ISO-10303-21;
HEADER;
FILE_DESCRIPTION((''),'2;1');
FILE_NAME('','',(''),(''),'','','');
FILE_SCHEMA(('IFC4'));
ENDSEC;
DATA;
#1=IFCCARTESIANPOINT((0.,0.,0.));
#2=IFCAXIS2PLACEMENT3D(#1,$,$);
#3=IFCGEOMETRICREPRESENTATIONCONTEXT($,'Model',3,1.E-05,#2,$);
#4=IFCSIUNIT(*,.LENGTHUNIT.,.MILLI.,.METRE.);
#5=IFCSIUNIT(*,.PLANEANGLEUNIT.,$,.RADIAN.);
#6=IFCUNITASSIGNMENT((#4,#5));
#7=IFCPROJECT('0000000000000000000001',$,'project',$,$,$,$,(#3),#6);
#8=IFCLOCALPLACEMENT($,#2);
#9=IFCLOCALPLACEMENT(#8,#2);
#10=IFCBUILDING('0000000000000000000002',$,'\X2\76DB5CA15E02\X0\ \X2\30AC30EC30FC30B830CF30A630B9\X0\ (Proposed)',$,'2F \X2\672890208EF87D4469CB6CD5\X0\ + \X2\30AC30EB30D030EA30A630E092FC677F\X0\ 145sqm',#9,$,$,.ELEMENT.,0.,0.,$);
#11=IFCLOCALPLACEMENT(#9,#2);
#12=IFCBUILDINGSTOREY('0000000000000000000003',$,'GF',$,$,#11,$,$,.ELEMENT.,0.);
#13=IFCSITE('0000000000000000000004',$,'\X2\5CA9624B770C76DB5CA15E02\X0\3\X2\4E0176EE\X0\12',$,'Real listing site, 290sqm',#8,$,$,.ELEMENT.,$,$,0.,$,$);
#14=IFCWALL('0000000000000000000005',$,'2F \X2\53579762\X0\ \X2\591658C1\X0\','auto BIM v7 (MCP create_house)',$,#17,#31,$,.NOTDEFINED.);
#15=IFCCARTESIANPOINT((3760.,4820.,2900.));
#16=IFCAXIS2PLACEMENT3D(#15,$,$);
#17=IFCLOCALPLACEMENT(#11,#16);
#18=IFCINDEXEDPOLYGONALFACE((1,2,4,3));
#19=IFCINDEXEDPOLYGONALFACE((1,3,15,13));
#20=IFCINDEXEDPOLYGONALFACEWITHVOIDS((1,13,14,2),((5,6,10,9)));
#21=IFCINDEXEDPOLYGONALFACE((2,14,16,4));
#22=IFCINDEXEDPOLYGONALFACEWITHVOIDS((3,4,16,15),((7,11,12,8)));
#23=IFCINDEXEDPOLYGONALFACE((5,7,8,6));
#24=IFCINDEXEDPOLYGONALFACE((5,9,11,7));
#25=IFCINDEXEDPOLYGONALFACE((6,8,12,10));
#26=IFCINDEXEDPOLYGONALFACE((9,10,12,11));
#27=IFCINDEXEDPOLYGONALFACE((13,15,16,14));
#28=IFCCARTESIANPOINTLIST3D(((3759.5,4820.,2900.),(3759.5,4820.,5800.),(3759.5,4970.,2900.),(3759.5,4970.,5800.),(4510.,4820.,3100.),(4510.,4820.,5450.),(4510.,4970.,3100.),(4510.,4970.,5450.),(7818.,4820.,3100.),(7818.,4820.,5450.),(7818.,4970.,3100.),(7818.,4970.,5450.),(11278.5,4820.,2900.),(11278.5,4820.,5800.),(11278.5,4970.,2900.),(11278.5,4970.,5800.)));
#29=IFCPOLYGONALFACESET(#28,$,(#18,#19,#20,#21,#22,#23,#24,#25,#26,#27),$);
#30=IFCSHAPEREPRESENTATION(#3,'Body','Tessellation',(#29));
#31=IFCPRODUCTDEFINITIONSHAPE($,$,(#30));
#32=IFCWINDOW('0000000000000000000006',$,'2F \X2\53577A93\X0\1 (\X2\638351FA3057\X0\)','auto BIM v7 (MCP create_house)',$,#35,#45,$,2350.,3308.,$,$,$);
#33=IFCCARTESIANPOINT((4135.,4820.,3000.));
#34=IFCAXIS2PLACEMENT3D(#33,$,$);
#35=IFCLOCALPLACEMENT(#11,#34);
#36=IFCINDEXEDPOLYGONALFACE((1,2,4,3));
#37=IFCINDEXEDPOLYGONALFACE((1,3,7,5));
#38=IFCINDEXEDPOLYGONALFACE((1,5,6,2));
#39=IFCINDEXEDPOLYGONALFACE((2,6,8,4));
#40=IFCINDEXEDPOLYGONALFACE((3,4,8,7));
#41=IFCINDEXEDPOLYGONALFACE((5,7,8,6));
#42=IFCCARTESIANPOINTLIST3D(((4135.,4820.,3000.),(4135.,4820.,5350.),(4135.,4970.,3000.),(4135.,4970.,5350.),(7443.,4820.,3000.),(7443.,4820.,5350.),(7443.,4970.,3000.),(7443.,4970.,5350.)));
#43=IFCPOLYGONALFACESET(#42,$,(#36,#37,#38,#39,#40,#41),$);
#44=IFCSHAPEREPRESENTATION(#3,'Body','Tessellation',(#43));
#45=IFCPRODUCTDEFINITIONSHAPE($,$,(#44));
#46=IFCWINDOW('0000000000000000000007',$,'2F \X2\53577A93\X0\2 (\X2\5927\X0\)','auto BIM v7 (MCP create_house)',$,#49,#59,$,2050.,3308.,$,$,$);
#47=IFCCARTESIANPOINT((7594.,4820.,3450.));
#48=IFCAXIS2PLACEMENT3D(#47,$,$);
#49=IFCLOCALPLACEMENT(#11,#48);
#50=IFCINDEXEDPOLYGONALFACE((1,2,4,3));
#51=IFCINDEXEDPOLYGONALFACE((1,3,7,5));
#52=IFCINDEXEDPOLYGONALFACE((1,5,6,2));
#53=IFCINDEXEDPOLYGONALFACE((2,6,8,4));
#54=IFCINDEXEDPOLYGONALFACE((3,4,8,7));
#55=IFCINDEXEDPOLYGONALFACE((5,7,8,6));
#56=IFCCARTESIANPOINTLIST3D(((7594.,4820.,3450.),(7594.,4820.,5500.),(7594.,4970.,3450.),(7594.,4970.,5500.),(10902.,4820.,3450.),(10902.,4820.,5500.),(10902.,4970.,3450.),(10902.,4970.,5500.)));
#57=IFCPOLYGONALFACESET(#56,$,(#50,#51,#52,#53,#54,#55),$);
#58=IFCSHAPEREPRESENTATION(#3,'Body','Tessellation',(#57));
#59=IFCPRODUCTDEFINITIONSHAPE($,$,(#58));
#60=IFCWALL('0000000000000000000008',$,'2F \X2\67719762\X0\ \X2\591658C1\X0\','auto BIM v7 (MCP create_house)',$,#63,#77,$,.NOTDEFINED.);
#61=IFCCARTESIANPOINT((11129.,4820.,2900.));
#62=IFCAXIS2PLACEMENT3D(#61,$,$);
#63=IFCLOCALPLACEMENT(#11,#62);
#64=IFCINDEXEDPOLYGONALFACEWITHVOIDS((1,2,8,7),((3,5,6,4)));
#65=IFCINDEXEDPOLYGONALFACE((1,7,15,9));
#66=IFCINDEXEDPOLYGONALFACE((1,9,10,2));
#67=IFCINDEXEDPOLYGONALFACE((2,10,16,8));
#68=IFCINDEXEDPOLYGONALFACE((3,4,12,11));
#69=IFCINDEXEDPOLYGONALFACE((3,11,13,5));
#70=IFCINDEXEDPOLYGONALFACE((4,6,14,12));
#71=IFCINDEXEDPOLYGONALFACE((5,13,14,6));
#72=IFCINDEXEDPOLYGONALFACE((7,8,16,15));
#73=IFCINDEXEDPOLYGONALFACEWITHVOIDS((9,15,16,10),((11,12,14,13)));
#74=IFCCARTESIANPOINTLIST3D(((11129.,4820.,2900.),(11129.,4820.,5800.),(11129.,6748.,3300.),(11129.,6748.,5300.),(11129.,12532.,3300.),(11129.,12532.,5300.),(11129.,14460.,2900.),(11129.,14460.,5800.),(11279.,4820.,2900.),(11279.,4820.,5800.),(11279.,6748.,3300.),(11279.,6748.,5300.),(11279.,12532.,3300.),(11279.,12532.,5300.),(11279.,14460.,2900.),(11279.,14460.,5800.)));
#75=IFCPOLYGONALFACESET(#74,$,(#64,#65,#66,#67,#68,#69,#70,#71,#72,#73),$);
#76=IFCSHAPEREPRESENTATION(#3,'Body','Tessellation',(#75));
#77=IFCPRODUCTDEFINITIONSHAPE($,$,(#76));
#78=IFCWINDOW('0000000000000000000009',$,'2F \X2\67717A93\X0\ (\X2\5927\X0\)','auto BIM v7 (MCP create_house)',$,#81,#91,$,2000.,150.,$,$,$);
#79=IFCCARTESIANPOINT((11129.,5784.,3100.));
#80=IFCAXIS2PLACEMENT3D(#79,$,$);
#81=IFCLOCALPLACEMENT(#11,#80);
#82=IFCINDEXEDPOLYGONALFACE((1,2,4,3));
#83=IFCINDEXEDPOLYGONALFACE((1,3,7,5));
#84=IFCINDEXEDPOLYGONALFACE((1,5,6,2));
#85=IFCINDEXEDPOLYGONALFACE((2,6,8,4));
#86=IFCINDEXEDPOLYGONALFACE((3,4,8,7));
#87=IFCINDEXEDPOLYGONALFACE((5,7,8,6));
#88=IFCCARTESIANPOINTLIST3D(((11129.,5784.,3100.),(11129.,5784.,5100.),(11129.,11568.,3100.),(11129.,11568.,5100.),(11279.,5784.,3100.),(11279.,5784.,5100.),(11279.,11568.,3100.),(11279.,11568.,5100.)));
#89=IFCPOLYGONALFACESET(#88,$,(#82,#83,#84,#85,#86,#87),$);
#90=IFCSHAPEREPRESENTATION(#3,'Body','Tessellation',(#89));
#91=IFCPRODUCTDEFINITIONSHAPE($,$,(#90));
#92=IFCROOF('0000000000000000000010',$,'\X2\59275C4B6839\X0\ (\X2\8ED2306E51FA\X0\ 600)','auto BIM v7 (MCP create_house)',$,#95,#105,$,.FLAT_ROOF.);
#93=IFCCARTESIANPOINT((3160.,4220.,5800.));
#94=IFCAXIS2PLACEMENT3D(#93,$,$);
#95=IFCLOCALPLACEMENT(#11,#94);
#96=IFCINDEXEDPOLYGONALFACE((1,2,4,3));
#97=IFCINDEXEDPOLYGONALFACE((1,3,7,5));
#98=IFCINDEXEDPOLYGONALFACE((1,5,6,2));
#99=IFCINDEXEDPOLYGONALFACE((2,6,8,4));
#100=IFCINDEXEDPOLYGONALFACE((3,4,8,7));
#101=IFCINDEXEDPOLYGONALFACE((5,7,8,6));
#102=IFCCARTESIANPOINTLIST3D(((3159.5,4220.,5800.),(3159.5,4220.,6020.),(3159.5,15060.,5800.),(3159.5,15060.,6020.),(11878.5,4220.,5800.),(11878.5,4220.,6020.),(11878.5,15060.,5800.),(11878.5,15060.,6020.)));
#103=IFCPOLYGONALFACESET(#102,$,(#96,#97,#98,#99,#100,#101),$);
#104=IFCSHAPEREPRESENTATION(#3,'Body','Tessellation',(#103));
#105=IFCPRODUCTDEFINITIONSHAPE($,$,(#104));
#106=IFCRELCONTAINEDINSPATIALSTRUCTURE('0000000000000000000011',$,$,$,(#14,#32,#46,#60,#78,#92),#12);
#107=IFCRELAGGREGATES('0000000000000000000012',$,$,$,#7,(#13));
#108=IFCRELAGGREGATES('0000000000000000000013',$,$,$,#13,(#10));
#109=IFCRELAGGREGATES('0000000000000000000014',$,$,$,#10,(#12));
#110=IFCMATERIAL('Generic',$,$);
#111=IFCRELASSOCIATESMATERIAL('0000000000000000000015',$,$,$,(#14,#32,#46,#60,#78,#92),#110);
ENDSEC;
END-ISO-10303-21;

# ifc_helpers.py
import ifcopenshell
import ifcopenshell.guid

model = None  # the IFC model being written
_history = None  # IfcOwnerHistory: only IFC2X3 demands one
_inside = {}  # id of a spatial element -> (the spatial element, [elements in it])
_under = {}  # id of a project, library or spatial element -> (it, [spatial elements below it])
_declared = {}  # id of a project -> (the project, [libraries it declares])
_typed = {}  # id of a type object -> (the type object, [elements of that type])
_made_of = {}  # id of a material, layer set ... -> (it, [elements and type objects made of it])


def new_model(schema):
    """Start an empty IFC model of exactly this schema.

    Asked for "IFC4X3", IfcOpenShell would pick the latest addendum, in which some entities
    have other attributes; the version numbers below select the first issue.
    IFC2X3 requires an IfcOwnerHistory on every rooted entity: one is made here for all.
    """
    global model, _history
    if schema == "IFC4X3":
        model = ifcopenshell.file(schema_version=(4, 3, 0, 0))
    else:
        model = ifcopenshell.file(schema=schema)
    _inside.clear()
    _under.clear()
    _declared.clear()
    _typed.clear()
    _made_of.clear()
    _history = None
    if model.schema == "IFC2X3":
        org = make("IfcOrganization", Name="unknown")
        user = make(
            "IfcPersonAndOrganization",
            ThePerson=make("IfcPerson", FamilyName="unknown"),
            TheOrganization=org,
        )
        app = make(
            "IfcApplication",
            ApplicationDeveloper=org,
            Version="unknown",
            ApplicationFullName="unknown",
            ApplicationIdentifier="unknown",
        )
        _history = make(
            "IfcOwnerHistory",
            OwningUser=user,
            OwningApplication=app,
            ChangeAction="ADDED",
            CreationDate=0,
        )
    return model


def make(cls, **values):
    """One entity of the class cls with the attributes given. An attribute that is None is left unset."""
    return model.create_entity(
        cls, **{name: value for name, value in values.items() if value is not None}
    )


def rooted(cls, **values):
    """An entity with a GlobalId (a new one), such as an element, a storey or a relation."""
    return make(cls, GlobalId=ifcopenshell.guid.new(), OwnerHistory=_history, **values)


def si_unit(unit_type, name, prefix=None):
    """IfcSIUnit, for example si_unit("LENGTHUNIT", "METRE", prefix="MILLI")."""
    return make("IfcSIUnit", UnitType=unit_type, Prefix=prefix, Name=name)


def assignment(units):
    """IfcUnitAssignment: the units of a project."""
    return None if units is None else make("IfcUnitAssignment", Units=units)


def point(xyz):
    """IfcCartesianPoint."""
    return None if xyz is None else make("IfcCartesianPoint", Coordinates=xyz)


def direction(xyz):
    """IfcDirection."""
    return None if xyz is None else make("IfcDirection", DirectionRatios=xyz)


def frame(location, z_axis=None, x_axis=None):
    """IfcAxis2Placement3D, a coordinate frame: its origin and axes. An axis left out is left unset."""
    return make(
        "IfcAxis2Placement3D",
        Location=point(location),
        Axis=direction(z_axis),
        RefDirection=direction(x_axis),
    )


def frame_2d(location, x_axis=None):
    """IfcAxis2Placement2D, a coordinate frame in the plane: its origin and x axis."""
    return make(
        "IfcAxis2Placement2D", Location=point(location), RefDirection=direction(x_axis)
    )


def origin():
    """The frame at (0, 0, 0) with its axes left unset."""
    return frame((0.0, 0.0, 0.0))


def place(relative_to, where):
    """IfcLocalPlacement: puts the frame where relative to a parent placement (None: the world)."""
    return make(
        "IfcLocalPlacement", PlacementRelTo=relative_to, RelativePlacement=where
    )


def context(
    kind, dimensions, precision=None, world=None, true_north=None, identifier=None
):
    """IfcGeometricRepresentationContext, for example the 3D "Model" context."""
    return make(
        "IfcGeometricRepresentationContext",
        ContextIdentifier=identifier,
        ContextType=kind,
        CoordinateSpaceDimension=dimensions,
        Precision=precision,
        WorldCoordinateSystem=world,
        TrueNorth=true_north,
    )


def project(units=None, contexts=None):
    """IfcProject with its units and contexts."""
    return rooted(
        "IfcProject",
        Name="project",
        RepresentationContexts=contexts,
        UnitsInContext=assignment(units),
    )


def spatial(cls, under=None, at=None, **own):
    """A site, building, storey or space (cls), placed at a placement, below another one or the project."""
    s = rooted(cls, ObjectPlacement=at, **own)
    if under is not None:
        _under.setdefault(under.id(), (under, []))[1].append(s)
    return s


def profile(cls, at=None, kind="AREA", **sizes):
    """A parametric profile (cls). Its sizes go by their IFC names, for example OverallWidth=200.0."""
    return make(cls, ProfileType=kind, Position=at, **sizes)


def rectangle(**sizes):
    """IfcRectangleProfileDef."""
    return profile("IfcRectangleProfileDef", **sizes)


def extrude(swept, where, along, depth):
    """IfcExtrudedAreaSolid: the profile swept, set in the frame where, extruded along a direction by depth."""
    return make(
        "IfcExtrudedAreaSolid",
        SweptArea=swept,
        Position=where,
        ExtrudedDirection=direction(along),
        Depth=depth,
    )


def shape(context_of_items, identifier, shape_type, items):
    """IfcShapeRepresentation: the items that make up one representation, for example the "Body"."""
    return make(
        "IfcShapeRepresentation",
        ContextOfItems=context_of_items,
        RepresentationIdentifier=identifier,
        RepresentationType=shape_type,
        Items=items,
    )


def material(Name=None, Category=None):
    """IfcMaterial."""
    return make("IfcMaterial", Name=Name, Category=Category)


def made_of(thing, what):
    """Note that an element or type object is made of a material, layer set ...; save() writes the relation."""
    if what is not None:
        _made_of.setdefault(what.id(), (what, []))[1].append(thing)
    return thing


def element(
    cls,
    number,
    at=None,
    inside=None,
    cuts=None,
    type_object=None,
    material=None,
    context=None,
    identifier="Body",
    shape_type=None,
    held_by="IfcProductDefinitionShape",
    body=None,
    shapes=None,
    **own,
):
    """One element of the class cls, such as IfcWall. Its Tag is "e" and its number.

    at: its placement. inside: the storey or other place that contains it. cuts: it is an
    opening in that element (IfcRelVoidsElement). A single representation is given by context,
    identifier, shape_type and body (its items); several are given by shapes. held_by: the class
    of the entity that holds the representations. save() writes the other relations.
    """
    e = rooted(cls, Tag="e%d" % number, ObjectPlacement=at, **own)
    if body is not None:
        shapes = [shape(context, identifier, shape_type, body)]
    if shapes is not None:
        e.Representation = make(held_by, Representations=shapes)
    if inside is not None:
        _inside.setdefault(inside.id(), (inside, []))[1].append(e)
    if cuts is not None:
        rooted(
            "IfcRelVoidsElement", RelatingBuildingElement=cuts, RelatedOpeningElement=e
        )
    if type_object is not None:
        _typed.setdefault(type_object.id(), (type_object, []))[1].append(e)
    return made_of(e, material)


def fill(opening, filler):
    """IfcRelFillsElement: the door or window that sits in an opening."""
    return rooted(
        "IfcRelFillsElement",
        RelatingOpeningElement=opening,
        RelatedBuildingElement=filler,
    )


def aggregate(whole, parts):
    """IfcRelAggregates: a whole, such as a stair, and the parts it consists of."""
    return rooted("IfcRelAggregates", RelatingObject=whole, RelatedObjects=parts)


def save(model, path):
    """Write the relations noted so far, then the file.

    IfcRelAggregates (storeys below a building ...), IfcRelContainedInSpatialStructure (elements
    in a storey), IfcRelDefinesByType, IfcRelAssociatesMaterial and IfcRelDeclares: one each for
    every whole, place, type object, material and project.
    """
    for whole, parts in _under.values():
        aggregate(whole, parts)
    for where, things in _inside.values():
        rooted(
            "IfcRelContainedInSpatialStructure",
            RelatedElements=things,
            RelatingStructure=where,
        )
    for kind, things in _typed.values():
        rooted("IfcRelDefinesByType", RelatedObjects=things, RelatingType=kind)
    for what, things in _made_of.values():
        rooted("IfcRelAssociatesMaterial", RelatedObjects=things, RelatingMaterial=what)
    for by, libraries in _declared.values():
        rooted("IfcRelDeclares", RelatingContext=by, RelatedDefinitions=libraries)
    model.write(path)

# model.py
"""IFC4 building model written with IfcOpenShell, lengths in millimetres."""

from ifc_helpers import new_model, si_unit, frame, frame_2d, origin, place, context, project, spatial, rectangle, extrude, material, element, fill, save


model = new_model("IFC4")

# Units and contexts
model_context = context("Model", 3, precision=1e-05, world=origin())
ifc_project = project(units=[si_unit("LENGTHUNIT", "METRE", prefix="MILLI"), si_unit("PLANEANGLEUNIT", "RADIAN")], contexts=[model_context])

# Site, building, storey
site_placement = place(None, origin())
site = spatial("IfcSite", under=ifc_project, at=site_placement, Name="岩手県盛岡市3丁目12", ObjectType="Real listing site, 290sqm", CompositionType="ELEMENT", RefElevation=0.0)
building_placement = place(site_placement, origin())
building = spatial("IfcBuilding", under=site, at=building_placement, Name="盛岡市 ガレージハウス (Proposed)", ObjectType="2F 木造軸組構法 + ガルバリウム鋼板 145sqm", CompositionType="ELEMENT", ElevationOfRefHeight=0.0, ElevationOfTerrain=0.0)
storey_placement = place(building_placement, origin())
storey = spatial("IfcBuildingStorey", under=building, at=storey_placement, Name="GF", CompositionType="ELEMENT", Elevation=0.0)

# Shared definitions
ifc_material = material(Name="Generic")

# Wall, openings, windows
wall_1_placement = place(storey_placement, frame((3760.0, 4820.0, 2900.0)))
wall_1 = element("IfcWall", 1, at=wall_1_placement, inside=storey, material=ifc_material, Name="2F 南面 外壁", Description="auto BIM v7 (MCP create_house)", PredefinedType="NOTDEFINED", context=model_context, shape_type="SweptSolid", body=[
    extrude(rectangle(XDim=7519.0, YDim=150.0, at=frame_2d((3759.0, 75.0))), frame((3760.0, 4820.0, 2900.0)), (0.0, 0.0, 1.0), 2900.0),
])
opening_1_placement = place(storey_placement, frame((4135.0, 4820.0, 3000.0)))
opening_1 = element("IfcOpeningElement", 2, at=opening_1_placement, cuts=wall_1, PredefinedType="NOTDEFINED", context=model_context, shape_type="SweptSolid", body=[
    extrude(rectangle(XDim=3308.0, YDim=150.0, at=frame_2d((1654.0, 75.0))), frame((4135.0, 4820.0, 3000.0)), (0.0, 0.0, 1.0), 2350.0),
])
opening_2_placement = place(storey_placement, frame((7594.0, 4820.0, 3450.0)))
opening_2 = element("IfcOpeningElement", 3, at=opening_2_placement, cuts=wall_1, PredefinedType="NOTDEFINED", context=model_context, shape_type="SweptSolid", body=[
    extrude(rectangle(XDim=3308.0, YDim=150.0, at=frame_2d((1654.0, 75.0))), frame((7594.0, 4820.0, 3450.0)), (0.0, 0.0, 1.0), 2050.0),
])
window_1_placement = place(storey_placement, frame((4135.0, 4820.0, 3000.0)))
window_1 = element("IfcWindow", 4, at=window_1_placement, inside=storey, material=ifc_material, Name="2F 南窓1 (掃出し)", Description="auto BIM v7 (MCP create_house)", OverallHeight=2350.0, OverallWidth=3308.0, context=model_context, shape_type="SweptSolid", body=[
    extrude(rectangle(XDim=3308.0, YDim=150.0, at=frame_2d((1654.0, 75.0))), frame((4135.0, 4820.0, 3000.0)), (0.0, 0.0, 1.0), 2350.0),
])
fill(opening_1, window_1)
window_2_placement = place(storey_placement, frame((7594.0, 4820.0, 3450.0)))
window_2 = element("IfcWindow", 5, at=window_2_placement, inside=storey, material=ifc_material, Name="2F 南窓2 (大)", Description="auto BIM v7 (MCP create_house)", OverallHeight=2050.0, OverallWidth=3308.0, context=model_context, shape_type="SweptSolid", body=[
    extrude(rectangle(XDim=3308.0, YDim=150.0, at=frame_2d((1654.0, 75.0))), frame((7594.0, 4820.0, 3450.0)), (0.0, 0.0, 1.0), 2050.0),
])
fill(opening_2, window_2)

# Wall, opening, window
wall_2_placement = place(storey_placement, frame((11129.0, 4820.0, 2900.0)))
wall_2 = element("IfcWall", 6, at=wall_2_placement, inside=storey, material=ifc_material, Name="2F 東面 外壁", Description="auto BIM v7 (MCP create_house)", PredefinedType="NOTDEFINED", context=model_context, shape_type="SweptSolid", body=[
    extrude(rectangle(XDim=150.0, YDim=9640.0, at=frame_2d((75.0, 4820.0))), frame((11129.0, 4820.0, 2900.0)), (0.0, 0.0, 1.0), 2900.0),
])
opening_3_placement = place(storey_placement, frame((11129.0, 5784.0, 3100.0)))
opening_3 = element("IfcOpeningElement", 7, at=opening_3_placement, cuts=wall_2, PredefinedType="NOTDEFINED", context=model_context, shape_type="SweptSolid", body=[
    extrude(rectangle(XDim=150.0, YDim=5784.0, at=frame_2d((75.0, 2892.0))), frame((11129.0, 5784.0, 3100.0)), (0.0, 0.0, 1.0), 2000.0),
])
window_3_placement = place(storey_placement, frame((11129.0, 5784.0, 3100.0)))
window_3 = element("IfcWindow", 8, at=window_3_placement, inside=storey, material=ifc_material, Name="2F 東窓 (大)", Description="auto BIM v7 (MCP create_house)", OverallHeight=2000.0, OverallWidth=150.0, context=model_context, shape_type="SweptSolid", body=[
    extrude(rectangle(XDim=150.0, YDim=5784.0, at=frame_2d((75.0, 2892.0))), frame((11129.0, 5784.0, 3100.0)), (0.0, 0.0, 1.0), 2000.0),
])
fill(opening_3, window_3)

# Roof
roof_placement = place(storey_placement, frame((3160.0, 4220.0, 5800.0)))
element("IfcRoof", 9, at=roof_placement, inside=storey, material=ifc_material, Name="大屋根 (軒の出 600)", Description="auto BIM v7 (MCP create_house)", PredefinedType="FLAT_ROOF", context=model_context, shape_type="SweptSolid", body=[
    extrude(rectangle(XDim=8719.0, YDim=10840.0, at=frame_2d((4359.0, 5420.0))), frame((3160.0, 4220.0, 5800.0)), (0.0, 0.0, 1.0), 220.0),
])

save(model, "model.ifc")
